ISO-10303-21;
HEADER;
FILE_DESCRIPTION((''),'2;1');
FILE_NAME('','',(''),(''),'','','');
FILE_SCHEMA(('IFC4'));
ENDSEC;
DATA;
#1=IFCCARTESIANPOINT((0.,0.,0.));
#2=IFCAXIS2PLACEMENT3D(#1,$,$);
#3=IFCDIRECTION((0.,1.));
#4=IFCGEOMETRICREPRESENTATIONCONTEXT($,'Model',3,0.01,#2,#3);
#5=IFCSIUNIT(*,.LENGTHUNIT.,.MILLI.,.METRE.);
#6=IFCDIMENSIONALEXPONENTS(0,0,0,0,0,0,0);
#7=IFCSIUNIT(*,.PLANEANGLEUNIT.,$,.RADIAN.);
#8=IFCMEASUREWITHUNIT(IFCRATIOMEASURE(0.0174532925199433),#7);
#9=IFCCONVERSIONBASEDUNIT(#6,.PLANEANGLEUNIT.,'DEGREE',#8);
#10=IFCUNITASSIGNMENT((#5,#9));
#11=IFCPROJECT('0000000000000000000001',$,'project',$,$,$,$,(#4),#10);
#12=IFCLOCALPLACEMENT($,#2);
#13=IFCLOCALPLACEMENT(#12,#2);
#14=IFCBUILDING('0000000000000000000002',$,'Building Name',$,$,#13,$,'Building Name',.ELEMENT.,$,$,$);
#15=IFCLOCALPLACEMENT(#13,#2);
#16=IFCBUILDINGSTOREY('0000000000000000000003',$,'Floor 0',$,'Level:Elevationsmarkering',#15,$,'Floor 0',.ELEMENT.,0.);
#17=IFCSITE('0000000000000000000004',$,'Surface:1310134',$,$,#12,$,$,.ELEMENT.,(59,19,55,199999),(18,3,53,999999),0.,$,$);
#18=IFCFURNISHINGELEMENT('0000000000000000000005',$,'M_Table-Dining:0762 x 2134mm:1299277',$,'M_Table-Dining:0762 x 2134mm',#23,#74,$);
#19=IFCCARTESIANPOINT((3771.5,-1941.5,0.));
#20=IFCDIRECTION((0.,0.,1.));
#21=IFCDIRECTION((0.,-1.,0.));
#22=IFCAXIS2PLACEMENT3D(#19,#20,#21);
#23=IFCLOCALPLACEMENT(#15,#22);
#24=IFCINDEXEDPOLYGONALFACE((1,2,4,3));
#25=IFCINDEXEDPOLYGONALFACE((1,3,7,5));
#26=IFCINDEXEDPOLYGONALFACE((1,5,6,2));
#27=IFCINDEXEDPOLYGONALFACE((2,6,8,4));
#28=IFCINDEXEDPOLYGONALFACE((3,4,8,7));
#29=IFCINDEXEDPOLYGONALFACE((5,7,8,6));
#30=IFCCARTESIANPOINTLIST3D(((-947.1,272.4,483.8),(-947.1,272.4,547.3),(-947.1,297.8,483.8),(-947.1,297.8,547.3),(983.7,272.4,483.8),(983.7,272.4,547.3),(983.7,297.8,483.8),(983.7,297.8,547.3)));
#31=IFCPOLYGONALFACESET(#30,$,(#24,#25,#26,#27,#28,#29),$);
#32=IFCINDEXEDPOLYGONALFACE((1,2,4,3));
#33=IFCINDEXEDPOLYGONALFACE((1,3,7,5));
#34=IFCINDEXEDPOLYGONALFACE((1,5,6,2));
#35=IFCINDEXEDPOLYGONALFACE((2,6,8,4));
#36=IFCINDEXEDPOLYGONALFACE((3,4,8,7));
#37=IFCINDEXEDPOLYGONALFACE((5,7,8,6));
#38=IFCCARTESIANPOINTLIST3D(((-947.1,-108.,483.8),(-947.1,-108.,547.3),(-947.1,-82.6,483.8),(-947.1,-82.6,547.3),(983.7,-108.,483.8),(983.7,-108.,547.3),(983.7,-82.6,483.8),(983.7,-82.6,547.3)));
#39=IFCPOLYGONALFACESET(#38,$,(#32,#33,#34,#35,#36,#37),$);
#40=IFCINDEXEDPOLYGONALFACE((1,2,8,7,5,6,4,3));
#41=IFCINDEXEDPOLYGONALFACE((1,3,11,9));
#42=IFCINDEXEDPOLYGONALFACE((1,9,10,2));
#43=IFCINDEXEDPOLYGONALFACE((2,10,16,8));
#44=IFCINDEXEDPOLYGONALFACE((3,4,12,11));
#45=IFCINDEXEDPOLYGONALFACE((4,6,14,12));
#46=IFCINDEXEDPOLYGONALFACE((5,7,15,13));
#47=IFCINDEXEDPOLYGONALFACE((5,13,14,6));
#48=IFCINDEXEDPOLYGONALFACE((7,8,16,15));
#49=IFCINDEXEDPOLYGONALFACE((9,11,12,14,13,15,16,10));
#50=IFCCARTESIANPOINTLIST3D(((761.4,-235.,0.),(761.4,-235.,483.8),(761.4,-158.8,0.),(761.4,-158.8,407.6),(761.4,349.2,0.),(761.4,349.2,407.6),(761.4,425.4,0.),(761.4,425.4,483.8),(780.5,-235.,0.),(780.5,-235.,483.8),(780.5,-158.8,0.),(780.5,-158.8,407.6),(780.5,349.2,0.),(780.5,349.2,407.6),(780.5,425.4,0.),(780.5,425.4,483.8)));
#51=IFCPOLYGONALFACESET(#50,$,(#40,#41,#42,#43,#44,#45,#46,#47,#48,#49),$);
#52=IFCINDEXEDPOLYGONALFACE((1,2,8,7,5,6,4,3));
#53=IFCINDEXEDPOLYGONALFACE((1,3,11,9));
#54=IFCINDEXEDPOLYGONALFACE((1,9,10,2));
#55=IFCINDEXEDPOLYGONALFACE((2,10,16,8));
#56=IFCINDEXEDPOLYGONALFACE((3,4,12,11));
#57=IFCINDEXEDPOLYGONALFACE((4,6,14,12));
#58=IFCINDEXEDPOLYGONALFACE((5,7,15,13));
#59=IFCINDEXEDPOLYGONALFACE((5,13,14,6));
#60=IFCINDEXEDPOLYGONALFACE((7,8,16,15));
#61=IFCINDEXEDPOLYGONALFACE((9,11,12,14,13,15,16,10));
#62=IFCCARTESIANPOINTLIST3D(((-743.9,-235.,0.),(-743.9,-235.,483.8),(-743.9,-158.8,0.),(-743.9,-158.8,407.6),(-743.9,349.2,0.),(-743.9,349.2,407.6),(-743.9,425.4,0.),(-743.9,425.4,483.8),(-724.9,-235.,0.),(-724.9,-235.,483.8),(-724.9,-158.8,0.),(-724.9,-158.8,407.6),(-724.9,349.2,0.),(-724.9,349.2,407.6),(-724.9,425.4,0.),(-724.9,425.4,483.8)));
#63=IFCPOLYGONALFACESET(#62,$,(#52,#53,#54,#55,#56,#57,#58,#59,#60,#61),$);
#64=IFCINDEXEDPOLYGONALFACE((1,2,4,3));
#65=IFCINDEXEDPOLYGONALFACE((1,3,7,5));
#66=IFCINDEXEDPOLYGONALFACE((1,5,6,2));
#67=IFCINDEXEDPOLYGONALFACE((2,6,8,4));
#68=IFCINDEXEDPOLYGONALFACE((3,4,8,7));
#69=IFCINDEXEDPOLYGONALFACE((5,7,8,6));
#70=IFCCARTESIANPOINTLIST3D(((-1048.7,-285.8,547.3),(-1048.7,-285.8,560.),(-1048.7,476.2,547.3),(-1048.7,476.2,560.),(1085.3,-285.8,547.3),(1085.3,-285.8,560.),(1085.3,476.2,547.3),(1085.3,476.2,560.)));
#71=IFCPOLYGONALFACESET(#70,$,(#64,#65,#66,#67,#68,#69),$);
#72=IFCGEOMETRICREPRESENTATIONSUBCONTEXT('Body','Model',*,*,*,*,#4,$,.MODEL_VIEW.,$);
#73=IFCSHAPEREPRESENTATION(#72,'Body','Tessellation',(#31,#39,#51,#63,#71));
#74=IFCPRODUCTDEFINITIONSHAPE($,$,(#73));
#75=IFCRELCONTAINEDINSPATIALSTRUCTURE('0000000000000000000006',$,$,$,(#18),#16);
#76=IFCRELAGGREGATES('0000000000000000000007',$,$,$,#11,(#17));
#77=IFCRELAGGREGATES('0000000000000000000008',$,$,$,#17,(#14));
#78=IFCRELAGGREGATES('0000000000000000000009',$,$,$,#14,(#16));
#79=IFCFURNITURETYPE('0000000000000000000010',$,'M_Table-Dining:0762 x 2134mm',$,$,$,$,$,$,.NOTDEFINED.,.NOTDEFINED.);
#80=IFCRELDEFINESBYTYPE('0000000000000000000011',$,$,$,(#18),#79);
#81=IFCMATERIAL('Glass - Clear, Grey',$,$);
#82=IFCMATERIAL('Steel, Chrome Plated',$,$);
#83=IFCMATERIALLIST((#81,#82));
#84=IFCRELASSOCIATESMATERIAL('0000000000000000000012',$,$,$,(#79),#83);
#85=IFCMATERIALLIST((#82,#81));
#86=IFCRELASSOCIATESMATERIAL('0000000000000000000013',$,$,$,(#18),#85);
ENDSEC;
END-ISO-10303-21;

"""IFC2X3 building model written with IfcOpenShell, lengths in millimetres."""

from ifc_helpers import new_model, entity, si_unit, converted_unit, direction, frame, frame_2d, origin, origin_2d_with_axis, place, context, subcontext, project, spatial, polyline, rectangle, outline, extrude, source, transform, mapped, material, material_list, type_object, type_shapes, element, save


model = new_model("IFC2X3")

# Units and contexts
model_context = context("Model", 3, precision=0.01, world=origin(), true_north=direction((0.0, 1.0)))
body_context = subcontext(model_context, "Body", "Model", "MODEL_VIEW")
ifc_project = project(units=[si_unit("LENGTHUNIT", "METRE", prefix="MILLI"), converted_unit("PLANEANGLEUNIT", "DEGREE", entity("IfcRatioMeasure", 0.0174532925199433), si_unit("PLANEANGLEUNIT", "RADIAN"), dimensions=[0, 0, 0, 0, 0, 0, 0])], contexts=[model_context])

# Site, building, storey
site_placement = place(None, origin())
site = spatial("IfcSite", under=ifc_project, at=site_placement, Name="Surface:1310134", CompositionType="ELEMENT", RefLatitude=(59, 19, 55, 199999), RefLongitude=(18, 3, 53, 999999), RefElevation=0.0)
building_placement = place(site_placement, origin())
building = spatial("IfcBuilding", under=site, at=building_placement, Name="Building Name", LongName="Building Name", CompositionType="ELEMENT")
storey_placement = place(building_placement, origin())
storey = spatial("IfcBuildingStorey", under=building, at=storey_placement, Name="Floor 0", ObjectType="Level:Elevationsmarkering", LongName="Floor 0", CompositionType="ELEMENT", Elevation=0.0)

# Furnishing element
ifc_material_1 = material(Name="Steel, Chrome Plated")
ifc_material_2 = material(Name="Glass - Clear, Grey")
ifc_material_list_1 = material_list([ifc_material_1, ifc_material_2])
ifc_material_list_2 = material_list([ifc_material_2, ifc_material_1])
furniture_type_1 = type_object("IfcFurnitureType", Name="M_Table-Dining:0762 x 2134mm", material=ifc_material_list_2)
shared_shape_1 = source(origin(), body_context, "Body", "SweptSolid", [
    extrude(rectangle(XDim=1930.8, YDim=25.4, at=frame_2d((0.0, 0.0), x_axis=(1.0, 0.0))), frame((18.3, 285.1, 483.8), z_axis=(0.0, 0.0, 1.0), x_axis=(-1.0, 0.0, 0.0)), (0.0, 0.0, 1.0), 63.5),
    extrude(rectangle(XDim=1930.8, YDim=25.4, at=origin_2d_with_axis()), frame((18.3, -95.3, 483.8), z_axis=(0.0, 0.0, 1.0), x_axis=(-1.0, 0.0, 0.0)), (0.0, 0.0, 1.0), 63.5),
    extrude(outline(polyline([(-222.8, -330.2), (260.9, -330.2), (260.9, 330.2), (-222.8, 330.2), (-222.8, 254.0), (184.7, 254.0), (184.7, -254.0), (-222.8, -254.0), (-222.8, -330.2)])), frame((761.4, 95.2, 222.8), z_axis=(1.0, 0.0, 0.0), x_axis=(0.0, 0.0, 1.0)), (0.0, 0.0, 1.0), 19.1),
    extrude(outline(polyline([(-330.2, -260.9), (330.2, -260.9), (330.2, 222.8), (254.0, 222.8), (254.0, -184.7), (-254.0, -184.7), (-254.0, 222.8), (-330.2, 222.8), (-330.2, -260.9)])), frame((-743.9, 95.2, 222.8), z_axis=(1.0, 0.0, 0.0), x_axis=(0.0, -1.0, 0.0)), (0.0, 0.0, 1.0), 19.1),
    extrude(rectangle(XDim=2134.0, YDim=762.0, at=origin_2d_with_axis()), frame((18.3, 95.2, 547.3), z_axis=(0.0, 0.0, 1.0), x_axis=(-1.0, 0.0, 0.0)), (0.0, 0.0, 1.0), 12.7),
])
type_shapes(furniture_type_1, [shared_shape_1])
furnishing_1_placement = place(storey_placement, frame((3771.5, -1941.5, 0.0), z_axis=(0.0, 0.0, 1.0), x_axis=(0.0, -1.0, 0.0)))
element("IfcFurnishingElement", 1, at=furnishing_1_placement, inside=storey, type_object=furniture_type_1, material=ifc_material_list_1, Name="M_Table-Dining:0762 x 2134mm:1299277", ObjectType="M_Table-Dining:0762 x 2134mm", context=body_context, shape_type="MappedRepresentation", body=[
    mapped(shared_shape_1, transform((0.0, 0.0, 0.0), scale=1.0)),
])

save(model, "model.ifc")
